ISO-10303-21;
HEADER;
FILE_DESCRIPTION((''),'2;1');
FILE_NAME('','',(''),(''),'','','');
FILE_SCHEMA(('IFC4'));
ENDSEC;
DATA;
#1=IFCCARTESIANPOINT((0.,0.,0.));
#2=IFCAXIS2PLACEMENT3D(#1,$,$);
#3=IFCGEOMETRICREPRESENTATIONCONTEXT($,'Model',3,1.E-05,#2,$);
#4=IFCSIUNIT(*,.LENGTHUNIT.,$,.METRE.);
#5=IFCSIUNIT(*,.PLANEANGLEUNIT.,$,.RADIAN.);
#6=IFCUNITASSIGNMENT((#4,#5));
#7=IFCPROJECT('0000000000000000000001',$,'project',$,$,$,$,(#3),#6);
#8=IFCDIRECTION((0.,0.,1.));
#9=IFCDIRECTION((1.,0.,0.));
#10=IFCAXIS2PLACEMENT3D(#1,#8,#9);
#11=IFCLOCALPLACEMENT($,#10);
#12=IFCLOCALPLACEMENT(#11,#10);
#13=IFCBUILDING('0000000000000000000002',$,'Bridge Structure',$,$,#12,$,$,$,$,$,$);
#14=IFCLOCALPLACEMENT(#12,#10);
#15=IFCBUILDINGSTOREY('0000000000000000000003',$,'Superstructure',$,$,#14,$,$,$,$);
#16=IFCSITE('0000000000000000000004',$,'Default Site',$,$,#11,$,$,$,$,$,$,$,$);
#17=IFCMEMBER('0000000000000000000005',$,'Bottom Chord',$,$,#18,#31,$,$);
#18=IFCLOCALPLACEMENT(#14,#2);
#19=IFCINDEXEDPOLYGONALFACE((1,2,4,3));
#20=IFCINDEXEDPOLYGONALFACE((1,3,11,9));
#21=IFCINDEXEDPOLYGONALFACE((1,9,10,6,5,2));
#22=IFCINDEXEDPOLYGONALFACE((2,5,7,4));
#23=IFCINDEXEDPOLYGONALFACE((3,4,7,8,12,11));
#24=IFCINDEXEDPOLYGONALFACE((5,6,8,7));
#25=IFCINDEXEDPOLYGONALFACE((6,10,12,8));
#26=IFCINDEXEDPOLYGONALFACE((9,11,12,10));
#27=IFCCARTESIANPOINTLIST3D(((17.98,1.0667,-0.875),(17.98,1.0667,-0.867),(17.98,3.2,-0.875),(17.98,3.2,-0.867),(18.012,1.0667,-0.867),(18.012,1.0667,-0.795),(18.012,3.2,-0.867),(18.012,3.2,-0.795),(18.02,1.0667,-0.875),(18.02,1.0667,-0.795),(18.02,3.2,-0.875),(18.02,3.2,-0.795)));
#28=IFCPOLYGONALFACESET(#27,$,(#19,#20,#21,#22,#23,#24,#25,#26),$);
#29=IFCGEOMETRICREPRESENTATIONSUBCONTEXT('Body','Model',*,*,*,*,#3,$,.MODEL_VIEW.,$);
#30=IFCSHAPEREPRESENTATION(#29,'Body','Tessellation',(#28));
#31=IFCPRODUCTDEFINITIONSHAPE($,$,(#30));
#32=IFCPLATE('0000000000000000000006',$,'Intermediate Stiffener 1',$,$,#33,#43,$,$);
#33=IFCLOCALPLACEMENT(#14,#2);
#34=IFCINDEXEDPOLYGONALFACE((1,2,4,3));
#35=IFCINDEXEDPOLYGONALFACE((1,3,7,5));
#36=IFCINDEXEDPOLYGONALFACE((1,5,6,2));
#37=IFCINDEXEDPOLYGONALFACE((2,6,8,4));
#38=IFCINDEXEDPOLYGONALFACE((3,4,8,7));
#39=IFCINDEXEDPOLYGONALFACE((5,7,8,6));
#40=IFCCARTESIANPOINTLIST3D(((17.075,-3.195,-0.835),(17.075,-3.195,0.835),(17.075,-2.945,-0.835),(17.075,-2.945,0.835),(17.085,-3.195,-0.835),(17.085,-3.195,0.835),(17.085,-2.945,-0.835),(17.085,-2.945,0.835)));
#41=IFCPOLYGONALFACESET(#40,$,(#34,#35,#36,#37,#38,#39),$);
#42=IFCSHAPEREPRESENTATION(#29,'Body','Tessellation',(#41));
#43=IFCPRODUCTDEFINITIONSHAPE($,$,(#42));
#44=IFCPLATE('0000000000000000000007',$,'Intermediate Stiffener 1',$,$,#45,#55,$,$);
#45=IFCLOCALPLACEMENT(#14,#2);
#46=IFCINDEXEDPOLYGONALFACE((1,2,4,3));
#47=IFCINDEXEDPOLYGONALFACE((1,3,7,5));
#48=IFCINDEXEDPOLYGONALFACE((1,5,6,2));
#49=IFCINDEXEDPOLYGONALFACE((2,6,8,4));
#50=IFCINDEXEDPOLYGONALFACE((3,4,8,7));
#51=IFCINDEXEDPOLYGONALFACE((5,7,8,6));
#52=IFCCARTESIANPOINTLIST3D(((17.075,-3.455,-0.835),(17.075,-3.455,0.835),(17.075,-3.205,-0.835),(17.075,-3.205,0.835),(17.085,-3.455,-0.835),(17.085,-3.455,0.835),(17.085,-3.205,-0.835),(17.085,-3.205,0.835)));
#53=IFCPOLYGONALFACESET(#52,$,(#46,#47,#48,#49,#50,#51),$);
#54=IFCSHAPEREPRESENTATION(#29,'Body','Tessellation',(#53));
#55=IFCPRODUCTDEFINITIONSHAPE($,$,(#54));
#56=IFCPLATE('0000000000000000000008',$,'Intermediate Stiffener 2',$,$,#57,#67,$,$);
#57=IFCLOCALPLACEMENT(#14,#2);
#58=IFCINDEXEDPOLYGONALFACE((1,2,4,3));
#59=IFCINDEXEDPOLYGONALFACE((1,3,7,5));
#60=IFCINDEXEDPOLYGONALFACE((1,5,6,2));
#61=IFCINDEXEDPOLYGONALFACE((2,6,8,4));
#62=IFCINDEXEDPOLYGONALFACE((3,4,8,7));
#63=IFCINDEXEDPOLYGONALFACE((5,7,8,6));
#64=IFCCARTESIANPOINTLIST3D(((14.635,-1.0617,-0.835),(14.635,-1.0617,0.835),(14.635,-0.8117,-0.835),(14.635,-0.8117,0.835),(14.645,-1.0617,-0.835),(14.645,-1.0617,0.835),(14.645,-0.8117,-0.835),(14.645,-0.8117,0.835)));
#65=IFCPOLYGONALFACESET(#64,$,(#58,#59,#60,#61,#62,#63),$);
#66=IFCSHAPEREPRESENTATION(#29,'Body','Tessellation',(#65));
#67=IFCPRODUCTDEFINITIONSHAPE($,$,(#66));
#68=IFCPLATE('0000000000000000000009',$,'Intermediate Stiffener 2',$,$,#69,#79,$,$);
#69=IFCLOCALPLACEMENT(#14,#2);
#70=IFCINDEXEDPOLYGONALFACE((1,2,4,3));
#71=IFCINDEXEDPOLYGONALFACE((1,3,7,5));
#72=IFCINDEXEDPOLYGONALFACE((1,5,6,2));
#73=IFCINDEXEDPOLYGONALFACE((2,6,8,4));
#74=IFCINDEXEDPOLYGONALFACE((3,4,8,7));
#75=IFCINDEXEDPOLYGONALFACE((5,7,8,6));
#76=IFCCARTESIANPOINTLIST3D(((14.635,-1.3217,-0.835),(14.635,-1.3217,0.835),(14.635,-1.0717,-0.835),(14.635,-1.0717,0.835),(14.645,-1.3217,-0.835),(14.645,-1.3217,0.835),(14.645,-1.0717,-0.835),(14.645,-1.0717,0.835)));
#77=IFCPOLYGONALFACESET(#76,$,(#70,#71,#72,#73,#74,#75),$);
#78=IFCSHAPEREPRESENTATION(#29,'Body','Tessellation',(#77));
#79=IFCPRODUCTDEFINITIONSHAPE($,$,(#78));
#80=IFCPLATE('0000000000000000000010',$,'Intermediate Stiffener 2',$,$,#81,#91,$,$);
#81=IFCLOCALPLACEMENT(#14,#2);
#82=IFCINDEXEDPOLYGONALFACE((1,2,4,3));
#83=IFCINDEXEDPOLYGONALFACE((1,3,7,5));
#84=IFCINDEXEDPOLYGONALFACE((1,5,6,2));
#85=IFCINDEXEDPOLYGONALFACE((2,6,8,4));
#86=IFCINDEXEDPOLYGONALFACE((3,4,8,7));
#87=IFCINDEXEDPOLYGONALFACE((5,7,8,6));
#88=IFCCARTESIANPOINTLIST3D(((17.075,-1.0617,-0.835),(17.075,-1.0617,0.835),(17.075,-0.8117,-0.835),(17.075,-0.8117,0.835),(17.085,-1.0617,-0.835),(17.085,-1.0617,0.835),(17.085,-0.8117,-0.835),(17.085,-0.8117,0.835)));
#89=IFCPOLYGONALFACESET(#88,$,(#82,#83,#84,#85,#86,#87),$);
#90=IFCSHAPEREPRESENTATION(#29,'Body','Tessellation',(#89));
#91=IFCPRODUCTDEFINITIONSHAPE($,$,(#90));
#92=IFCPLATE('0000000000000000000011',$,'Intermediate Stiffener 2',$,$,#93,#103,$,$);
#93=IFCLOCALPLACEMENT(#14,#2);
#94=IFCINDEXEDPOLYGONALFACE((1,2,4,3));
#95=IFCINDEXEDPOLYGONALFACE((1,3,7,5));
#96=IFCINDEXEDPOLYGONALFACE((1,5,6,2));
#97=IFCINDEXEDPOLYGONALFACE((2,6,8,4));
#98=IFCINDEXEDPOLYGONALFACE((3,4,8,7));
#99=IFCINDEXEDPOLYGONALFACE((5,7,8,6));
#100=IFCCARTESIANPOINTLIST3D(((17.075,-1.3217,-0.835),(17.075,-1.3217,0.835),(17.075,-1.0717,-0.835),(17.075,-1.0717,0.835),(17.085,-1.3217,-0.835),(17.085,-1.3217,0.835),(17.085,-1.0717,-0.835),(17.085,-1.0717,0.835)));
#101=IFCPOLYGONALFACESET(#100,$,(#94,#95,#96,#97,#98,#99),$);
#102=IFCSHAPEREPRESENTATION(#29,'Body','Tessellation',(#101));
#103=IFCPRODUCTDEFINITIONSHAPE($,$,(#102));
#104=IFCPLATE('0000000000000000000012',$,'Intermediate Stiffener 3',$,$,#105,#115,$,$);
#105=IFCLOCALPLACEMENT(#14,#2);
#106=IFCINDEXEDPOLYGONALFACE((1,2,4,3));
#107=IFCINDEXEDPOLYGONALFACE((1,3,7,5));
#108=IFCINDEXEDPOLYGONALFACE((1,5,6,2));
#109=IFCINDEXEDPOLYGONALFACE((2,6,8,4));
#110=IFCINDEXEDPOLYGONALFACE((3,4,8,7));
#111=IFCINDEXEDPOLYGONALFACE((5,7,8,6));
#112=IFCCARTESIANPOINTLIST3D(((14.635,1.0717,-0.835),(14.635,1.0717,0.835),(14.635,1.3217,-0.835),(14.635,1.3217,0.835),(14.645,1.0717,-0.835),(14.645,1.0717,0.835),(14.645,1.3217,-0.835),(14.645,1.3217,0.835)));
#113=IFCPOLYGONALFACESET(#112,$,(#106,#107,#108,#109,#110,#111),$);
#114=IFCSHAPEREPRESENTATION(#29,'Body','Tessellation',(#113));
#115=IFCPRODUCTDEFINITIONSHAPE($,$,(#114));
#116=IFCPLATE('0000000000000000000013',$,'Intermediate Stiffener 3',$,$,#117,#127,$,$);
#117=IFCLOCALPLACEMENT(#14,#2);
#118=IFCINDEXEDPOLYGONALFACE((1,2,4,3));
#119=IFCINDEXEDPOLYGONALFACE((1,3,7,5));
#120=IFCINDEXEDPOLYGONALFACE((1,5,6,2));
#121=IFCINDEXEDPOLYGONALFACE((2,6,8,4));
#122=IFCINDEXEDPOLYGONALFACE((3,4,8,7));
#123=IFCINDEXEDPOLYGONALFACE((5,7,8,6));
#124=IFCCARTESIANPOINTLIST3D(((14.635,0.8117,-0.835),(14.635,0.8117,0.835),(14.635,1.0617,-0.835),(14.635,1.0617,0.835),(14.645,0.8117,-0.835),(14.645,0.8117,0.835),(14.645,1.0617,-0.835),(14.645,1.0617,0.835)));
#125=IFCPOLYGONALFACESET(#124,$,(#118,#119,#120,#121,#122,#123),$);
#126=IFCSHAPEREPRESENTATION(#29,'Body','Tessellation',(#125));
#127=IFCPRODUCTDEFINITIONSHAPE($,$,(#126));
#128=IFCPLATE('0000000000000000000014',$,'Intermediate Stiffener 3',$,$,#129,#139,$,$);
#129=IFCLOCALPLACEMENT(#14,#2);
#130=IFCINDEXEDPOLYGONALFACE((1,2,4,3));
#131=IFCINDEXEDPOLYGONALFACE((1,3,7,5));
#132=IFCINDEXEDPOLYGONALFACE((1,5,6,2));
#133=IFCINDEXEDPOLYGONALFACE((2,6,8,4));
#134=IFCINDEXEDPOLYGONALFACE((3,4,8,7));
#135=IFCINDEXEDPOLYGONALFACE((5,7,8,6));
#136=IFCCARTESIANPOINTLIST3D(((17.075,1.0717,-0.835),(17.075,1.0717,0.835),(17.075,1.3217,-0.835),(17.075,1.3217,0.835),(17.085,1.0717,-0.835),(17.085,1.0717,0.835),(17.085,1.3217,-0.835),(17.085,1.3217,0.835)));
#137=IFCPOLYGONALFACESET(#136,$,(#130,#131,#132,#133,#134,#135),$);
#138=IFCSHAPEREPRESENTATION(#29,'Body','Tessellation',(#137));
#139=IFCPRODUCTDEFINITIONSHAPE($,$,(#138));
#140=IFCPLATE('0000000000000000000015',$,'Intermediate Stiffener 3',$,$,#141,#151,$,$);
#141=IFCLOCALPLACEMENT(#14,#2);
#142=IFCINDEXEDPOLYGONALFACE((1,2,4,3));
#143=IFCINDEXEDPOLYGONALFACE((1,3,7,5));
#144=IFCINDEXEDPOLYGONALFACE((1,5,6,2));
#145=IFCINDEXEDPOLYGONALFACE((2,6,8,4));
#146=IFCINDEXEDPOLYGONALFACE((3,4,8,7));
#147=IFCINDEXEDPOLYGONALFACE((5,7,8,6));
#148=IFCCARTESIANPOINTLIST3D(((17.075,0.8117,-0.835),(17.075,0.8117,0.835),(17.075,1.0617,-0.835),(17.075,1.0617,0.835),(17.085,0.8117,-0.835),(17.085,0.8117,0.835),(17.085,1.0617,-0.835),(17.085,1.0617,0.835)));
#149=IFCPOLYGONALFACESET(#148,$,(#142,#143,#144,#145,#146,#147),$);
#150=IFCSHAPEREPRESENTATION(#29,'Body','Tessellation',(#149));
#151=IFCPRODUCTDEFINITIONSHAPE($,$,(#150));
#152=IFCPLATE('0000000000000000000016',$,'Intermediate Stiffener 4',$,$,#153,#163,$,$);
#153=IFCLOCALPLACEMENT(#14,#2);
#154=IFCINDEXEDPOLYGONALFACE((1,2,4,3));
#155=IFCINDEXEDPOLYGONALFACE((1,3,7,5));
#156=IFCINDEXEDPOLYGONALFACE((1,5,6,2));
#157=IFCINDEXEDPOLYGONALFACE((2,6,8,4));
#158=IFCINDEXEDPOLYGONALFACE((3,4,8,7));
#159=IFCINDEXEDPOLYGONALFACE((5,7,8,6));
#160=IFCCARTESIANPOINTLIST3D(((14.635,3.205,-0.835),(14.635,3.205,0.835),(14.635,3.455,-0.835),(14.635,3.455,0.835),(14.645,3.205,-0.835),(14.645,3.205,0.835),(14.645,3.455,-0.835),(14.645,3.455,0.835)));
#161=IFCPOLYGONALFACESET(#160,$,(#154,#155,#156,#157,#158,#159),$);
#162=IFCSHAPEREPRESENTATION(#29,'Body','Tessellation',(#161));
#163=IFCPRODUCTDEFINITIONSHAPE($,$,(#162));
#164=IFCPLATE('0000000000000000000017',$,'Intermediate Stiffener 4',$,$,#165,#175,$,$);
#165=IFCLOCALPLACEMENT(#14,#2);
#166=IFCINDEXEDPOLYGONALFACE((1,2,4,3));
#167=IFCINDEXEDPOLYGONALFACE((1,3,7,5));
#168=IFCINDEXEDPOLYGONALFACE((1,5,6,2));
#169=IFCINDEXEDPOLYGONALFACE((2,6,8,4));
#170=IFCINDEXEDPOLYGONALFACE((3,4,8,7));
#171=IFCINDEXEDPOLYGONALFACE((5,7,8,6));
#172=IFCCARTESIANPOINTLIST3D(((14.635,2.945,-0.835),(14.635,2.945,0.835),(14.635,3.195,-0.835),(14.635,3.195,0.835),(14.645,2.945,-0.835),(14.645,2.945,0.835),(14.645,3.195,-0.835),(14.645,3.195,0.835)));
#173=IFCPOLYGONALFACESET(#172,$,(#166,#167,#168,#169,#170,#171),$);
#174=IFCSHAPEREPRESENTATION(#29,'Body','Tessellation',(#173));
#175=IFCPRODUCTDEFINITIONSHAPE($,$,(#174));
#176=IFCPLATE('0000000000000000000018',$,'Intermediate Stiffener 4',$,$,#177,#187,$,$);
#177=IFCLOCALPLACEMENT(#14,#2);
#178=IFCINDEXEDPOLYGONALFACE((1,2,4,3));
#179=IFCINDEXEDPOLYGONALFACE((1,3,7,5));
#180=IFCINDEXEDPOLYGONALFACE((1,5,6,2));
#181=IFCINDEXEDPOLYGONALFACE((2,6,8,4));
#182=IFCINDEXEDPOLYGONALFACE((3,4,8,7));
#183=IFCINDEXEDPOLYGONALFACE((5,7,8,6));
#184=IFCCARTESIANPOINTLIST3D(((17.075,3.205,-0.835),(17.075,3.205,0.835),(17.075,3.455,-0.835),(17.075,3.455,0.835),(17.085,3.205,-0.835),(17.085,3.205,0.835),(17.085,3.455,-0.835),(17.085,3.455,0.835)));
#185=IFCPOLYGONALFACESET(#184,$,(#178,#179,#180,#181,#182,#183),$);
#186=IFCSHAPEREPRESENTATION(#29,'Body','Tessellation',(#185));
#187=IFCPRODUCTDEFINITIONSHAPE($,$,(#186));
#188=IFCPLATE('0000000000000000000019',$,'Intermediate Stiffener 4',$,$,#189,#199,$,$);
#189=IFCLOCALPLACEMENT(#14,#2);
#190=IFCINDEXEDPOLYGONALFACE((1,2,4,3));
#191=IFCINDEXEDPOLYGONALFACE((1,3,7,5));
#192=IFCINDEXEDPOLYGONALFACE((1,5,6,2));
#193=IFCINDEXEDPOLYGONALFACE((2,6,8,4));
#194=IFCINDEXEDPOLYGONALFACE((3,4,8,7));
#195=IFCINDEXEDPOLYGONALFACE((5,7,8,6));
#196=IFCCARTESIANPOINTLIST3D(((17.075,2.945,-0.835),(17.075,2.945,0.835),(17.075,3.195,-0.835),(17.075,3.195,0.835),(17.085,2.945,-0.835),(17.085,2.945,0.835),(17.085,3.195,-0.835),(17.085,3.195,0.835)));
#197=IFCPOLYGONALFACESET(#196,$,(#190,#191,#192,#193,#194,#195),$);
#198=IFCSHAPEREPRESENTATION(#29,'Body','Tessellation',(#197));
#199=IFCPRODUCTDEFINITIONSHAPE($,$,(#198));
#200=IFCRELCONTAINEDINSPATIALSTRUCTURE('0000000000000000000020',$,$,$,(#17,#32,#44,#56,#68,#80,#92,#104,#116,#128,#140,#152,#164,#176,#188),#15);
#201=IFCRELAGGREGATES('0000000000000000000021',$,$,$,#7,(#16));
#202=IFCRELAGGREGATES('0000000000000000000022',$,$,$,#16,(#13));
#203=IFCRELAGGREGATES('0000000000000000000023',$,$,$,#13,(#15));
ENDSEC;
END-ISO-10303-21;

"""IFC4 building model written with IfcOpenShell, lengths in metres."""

from ifc_helpers import new_model, si_unit, frame, origin, origin_with_axes, origin_2d_with_axis, place, context, subcontext, project, spatial, rectangle, l_section, extrude, element, save


model = new_model("IFC4")

# Units and contexts
model_context = context("Model", 3, precision=1e-05, world=origin())
body_context = subcontext(model_context, "Body", "Model", "MODEL_VIEW")
ifc_project = project(units=[si_unit("LENGTHUNIT", "METRE"), si_unit("PLANEANGLEUNIT", "RADIAN")], contexts=[model_context])

# Site, building, storey
site_placement = place(None, origin_with_axes())
site = spatial("IfcSite", under=ifc_project, at=site_placement, Name="Default Site")
building_placement = place(site_placement, origin_with_axes())
building = spatial("IfcBuilding", under=site, at=building_placement, Name="Bridge Structure")
storey_placement = place(building_placement, origin_with_axes())
storey = spatial("IfcBuildingStorey", under=building, at=storey_placement, Name="Superstructure")

# Member
member_1_placement = place(storey_placement, frame((18.0, 1.0667, -0.835), z_axis=(0.0, 1.0, 0.0), x_axis=(-1.0, 0.0, 0.0)))
element("IfcMember", 1, at=member_1_placement, inside=storey, Name="Bottom Chord", context=body_context, shape_type="SweptSolid", body=[
    extrude(l_section(Depth=0.08, Width=0.04, Thickness=0.008, at=origin_2d_with_axis()), origin_with_axes(), (0.0, 0.0, 1.0), 2.1333),
])

# Plates
for number, where, z_axis, x_axis, name in (
    (2, (17.08, -3.07, -0.835), (0.0, 0.0, 1.0), (1.0, 0.0, 0.0), "Intermediate Stiffener 1"),
    (3, (17.08, -3.33, -0.835), (0.0, 0.0, 1.0), (1.0, 0.0, 0.0), "Intermediate Stiffener 1"),
    (4, (14.64, -0.9367, -0.835), (0.0, 0.0, 1.0), (1.0, 0.0, 0.0), "Intermediate Stiffener 2"),
    (5, (14.64, -1.1967, -0.835), (0.0, 0.0, 1.0), (1.0, 0.0, 0.0), "Intermediate Stiffener 2"),
    (6, (17.08, -0.9367, -0.835), (0.0, 0.0, 1.0), (1.0, 0.0, 0.0), "Intermediate Stiffener 2"),
    (7, (17.08, -1.1967, -0.835), (0.0, 0.0, 1.0), (1.0, 0.0, 0.0), "Intermediate Stiffener 2"),
    (8, (14.64, 1.1967, -0.835), (0.0, 0.0, 1.0), (1.0, 0.0, 0.0), "Intermediate Stiffener 3"),
    (9, (14.64, 0.9367, -0.835), (0.0, 0.0, 1.0), (1.0, 0.0, 0.0), "Intermediate Stiffener 3"),
    (10, (17.08, 1.1967, -0.835), (0.0, 0.0, 1.0), (1.0, 0.0, 0.0), "Intermediate Stiffener 3"),
    (11, (17.08, 0.9367, -0.835), (0.0, 0.0, 1.0), (1.0, 0.0, 0.0), "Intermediate Stiffener 3"),
    (12, (14.64, 3.33, -0.835), (0.0, 0.0, 1.0), (1.0, 0.0, 0.0), "Intermediate Stiffener 4"),
    (13, (14.64, 3.07, -0.835), (0.0, 0.0, 1.0), (1.0, 0.0, 0.0), "Intermediate Stiffener 4"),
    (14, (17.08, 3.33, -0.835), (0.0, 0.0, 1.0), (1.0, 0.0, 0.0), "Intermediate Stiffener 4"),
    (15, (17.08, 3.07, -0.835), (0.0, 0.0, 1.0), (1.0, 0.0, 0.0), "Intermediate Stiffener 4"),
):
    element("IfcPlate", number, at=place(storey_placement, frame(where, z_axis=z_axis, x_axis=x_axis)), inside=storey, Name=name, context=body_context, shape_type="SweptSolid", body=[
        extrude(rectangle(XDim=0.01, YDim=0.25, at=origin_2d_with_axis()), origin_with_axes(), (0.0, 0.0, 1.0), 1.67),
    ])

save(model, "model.ifc")
